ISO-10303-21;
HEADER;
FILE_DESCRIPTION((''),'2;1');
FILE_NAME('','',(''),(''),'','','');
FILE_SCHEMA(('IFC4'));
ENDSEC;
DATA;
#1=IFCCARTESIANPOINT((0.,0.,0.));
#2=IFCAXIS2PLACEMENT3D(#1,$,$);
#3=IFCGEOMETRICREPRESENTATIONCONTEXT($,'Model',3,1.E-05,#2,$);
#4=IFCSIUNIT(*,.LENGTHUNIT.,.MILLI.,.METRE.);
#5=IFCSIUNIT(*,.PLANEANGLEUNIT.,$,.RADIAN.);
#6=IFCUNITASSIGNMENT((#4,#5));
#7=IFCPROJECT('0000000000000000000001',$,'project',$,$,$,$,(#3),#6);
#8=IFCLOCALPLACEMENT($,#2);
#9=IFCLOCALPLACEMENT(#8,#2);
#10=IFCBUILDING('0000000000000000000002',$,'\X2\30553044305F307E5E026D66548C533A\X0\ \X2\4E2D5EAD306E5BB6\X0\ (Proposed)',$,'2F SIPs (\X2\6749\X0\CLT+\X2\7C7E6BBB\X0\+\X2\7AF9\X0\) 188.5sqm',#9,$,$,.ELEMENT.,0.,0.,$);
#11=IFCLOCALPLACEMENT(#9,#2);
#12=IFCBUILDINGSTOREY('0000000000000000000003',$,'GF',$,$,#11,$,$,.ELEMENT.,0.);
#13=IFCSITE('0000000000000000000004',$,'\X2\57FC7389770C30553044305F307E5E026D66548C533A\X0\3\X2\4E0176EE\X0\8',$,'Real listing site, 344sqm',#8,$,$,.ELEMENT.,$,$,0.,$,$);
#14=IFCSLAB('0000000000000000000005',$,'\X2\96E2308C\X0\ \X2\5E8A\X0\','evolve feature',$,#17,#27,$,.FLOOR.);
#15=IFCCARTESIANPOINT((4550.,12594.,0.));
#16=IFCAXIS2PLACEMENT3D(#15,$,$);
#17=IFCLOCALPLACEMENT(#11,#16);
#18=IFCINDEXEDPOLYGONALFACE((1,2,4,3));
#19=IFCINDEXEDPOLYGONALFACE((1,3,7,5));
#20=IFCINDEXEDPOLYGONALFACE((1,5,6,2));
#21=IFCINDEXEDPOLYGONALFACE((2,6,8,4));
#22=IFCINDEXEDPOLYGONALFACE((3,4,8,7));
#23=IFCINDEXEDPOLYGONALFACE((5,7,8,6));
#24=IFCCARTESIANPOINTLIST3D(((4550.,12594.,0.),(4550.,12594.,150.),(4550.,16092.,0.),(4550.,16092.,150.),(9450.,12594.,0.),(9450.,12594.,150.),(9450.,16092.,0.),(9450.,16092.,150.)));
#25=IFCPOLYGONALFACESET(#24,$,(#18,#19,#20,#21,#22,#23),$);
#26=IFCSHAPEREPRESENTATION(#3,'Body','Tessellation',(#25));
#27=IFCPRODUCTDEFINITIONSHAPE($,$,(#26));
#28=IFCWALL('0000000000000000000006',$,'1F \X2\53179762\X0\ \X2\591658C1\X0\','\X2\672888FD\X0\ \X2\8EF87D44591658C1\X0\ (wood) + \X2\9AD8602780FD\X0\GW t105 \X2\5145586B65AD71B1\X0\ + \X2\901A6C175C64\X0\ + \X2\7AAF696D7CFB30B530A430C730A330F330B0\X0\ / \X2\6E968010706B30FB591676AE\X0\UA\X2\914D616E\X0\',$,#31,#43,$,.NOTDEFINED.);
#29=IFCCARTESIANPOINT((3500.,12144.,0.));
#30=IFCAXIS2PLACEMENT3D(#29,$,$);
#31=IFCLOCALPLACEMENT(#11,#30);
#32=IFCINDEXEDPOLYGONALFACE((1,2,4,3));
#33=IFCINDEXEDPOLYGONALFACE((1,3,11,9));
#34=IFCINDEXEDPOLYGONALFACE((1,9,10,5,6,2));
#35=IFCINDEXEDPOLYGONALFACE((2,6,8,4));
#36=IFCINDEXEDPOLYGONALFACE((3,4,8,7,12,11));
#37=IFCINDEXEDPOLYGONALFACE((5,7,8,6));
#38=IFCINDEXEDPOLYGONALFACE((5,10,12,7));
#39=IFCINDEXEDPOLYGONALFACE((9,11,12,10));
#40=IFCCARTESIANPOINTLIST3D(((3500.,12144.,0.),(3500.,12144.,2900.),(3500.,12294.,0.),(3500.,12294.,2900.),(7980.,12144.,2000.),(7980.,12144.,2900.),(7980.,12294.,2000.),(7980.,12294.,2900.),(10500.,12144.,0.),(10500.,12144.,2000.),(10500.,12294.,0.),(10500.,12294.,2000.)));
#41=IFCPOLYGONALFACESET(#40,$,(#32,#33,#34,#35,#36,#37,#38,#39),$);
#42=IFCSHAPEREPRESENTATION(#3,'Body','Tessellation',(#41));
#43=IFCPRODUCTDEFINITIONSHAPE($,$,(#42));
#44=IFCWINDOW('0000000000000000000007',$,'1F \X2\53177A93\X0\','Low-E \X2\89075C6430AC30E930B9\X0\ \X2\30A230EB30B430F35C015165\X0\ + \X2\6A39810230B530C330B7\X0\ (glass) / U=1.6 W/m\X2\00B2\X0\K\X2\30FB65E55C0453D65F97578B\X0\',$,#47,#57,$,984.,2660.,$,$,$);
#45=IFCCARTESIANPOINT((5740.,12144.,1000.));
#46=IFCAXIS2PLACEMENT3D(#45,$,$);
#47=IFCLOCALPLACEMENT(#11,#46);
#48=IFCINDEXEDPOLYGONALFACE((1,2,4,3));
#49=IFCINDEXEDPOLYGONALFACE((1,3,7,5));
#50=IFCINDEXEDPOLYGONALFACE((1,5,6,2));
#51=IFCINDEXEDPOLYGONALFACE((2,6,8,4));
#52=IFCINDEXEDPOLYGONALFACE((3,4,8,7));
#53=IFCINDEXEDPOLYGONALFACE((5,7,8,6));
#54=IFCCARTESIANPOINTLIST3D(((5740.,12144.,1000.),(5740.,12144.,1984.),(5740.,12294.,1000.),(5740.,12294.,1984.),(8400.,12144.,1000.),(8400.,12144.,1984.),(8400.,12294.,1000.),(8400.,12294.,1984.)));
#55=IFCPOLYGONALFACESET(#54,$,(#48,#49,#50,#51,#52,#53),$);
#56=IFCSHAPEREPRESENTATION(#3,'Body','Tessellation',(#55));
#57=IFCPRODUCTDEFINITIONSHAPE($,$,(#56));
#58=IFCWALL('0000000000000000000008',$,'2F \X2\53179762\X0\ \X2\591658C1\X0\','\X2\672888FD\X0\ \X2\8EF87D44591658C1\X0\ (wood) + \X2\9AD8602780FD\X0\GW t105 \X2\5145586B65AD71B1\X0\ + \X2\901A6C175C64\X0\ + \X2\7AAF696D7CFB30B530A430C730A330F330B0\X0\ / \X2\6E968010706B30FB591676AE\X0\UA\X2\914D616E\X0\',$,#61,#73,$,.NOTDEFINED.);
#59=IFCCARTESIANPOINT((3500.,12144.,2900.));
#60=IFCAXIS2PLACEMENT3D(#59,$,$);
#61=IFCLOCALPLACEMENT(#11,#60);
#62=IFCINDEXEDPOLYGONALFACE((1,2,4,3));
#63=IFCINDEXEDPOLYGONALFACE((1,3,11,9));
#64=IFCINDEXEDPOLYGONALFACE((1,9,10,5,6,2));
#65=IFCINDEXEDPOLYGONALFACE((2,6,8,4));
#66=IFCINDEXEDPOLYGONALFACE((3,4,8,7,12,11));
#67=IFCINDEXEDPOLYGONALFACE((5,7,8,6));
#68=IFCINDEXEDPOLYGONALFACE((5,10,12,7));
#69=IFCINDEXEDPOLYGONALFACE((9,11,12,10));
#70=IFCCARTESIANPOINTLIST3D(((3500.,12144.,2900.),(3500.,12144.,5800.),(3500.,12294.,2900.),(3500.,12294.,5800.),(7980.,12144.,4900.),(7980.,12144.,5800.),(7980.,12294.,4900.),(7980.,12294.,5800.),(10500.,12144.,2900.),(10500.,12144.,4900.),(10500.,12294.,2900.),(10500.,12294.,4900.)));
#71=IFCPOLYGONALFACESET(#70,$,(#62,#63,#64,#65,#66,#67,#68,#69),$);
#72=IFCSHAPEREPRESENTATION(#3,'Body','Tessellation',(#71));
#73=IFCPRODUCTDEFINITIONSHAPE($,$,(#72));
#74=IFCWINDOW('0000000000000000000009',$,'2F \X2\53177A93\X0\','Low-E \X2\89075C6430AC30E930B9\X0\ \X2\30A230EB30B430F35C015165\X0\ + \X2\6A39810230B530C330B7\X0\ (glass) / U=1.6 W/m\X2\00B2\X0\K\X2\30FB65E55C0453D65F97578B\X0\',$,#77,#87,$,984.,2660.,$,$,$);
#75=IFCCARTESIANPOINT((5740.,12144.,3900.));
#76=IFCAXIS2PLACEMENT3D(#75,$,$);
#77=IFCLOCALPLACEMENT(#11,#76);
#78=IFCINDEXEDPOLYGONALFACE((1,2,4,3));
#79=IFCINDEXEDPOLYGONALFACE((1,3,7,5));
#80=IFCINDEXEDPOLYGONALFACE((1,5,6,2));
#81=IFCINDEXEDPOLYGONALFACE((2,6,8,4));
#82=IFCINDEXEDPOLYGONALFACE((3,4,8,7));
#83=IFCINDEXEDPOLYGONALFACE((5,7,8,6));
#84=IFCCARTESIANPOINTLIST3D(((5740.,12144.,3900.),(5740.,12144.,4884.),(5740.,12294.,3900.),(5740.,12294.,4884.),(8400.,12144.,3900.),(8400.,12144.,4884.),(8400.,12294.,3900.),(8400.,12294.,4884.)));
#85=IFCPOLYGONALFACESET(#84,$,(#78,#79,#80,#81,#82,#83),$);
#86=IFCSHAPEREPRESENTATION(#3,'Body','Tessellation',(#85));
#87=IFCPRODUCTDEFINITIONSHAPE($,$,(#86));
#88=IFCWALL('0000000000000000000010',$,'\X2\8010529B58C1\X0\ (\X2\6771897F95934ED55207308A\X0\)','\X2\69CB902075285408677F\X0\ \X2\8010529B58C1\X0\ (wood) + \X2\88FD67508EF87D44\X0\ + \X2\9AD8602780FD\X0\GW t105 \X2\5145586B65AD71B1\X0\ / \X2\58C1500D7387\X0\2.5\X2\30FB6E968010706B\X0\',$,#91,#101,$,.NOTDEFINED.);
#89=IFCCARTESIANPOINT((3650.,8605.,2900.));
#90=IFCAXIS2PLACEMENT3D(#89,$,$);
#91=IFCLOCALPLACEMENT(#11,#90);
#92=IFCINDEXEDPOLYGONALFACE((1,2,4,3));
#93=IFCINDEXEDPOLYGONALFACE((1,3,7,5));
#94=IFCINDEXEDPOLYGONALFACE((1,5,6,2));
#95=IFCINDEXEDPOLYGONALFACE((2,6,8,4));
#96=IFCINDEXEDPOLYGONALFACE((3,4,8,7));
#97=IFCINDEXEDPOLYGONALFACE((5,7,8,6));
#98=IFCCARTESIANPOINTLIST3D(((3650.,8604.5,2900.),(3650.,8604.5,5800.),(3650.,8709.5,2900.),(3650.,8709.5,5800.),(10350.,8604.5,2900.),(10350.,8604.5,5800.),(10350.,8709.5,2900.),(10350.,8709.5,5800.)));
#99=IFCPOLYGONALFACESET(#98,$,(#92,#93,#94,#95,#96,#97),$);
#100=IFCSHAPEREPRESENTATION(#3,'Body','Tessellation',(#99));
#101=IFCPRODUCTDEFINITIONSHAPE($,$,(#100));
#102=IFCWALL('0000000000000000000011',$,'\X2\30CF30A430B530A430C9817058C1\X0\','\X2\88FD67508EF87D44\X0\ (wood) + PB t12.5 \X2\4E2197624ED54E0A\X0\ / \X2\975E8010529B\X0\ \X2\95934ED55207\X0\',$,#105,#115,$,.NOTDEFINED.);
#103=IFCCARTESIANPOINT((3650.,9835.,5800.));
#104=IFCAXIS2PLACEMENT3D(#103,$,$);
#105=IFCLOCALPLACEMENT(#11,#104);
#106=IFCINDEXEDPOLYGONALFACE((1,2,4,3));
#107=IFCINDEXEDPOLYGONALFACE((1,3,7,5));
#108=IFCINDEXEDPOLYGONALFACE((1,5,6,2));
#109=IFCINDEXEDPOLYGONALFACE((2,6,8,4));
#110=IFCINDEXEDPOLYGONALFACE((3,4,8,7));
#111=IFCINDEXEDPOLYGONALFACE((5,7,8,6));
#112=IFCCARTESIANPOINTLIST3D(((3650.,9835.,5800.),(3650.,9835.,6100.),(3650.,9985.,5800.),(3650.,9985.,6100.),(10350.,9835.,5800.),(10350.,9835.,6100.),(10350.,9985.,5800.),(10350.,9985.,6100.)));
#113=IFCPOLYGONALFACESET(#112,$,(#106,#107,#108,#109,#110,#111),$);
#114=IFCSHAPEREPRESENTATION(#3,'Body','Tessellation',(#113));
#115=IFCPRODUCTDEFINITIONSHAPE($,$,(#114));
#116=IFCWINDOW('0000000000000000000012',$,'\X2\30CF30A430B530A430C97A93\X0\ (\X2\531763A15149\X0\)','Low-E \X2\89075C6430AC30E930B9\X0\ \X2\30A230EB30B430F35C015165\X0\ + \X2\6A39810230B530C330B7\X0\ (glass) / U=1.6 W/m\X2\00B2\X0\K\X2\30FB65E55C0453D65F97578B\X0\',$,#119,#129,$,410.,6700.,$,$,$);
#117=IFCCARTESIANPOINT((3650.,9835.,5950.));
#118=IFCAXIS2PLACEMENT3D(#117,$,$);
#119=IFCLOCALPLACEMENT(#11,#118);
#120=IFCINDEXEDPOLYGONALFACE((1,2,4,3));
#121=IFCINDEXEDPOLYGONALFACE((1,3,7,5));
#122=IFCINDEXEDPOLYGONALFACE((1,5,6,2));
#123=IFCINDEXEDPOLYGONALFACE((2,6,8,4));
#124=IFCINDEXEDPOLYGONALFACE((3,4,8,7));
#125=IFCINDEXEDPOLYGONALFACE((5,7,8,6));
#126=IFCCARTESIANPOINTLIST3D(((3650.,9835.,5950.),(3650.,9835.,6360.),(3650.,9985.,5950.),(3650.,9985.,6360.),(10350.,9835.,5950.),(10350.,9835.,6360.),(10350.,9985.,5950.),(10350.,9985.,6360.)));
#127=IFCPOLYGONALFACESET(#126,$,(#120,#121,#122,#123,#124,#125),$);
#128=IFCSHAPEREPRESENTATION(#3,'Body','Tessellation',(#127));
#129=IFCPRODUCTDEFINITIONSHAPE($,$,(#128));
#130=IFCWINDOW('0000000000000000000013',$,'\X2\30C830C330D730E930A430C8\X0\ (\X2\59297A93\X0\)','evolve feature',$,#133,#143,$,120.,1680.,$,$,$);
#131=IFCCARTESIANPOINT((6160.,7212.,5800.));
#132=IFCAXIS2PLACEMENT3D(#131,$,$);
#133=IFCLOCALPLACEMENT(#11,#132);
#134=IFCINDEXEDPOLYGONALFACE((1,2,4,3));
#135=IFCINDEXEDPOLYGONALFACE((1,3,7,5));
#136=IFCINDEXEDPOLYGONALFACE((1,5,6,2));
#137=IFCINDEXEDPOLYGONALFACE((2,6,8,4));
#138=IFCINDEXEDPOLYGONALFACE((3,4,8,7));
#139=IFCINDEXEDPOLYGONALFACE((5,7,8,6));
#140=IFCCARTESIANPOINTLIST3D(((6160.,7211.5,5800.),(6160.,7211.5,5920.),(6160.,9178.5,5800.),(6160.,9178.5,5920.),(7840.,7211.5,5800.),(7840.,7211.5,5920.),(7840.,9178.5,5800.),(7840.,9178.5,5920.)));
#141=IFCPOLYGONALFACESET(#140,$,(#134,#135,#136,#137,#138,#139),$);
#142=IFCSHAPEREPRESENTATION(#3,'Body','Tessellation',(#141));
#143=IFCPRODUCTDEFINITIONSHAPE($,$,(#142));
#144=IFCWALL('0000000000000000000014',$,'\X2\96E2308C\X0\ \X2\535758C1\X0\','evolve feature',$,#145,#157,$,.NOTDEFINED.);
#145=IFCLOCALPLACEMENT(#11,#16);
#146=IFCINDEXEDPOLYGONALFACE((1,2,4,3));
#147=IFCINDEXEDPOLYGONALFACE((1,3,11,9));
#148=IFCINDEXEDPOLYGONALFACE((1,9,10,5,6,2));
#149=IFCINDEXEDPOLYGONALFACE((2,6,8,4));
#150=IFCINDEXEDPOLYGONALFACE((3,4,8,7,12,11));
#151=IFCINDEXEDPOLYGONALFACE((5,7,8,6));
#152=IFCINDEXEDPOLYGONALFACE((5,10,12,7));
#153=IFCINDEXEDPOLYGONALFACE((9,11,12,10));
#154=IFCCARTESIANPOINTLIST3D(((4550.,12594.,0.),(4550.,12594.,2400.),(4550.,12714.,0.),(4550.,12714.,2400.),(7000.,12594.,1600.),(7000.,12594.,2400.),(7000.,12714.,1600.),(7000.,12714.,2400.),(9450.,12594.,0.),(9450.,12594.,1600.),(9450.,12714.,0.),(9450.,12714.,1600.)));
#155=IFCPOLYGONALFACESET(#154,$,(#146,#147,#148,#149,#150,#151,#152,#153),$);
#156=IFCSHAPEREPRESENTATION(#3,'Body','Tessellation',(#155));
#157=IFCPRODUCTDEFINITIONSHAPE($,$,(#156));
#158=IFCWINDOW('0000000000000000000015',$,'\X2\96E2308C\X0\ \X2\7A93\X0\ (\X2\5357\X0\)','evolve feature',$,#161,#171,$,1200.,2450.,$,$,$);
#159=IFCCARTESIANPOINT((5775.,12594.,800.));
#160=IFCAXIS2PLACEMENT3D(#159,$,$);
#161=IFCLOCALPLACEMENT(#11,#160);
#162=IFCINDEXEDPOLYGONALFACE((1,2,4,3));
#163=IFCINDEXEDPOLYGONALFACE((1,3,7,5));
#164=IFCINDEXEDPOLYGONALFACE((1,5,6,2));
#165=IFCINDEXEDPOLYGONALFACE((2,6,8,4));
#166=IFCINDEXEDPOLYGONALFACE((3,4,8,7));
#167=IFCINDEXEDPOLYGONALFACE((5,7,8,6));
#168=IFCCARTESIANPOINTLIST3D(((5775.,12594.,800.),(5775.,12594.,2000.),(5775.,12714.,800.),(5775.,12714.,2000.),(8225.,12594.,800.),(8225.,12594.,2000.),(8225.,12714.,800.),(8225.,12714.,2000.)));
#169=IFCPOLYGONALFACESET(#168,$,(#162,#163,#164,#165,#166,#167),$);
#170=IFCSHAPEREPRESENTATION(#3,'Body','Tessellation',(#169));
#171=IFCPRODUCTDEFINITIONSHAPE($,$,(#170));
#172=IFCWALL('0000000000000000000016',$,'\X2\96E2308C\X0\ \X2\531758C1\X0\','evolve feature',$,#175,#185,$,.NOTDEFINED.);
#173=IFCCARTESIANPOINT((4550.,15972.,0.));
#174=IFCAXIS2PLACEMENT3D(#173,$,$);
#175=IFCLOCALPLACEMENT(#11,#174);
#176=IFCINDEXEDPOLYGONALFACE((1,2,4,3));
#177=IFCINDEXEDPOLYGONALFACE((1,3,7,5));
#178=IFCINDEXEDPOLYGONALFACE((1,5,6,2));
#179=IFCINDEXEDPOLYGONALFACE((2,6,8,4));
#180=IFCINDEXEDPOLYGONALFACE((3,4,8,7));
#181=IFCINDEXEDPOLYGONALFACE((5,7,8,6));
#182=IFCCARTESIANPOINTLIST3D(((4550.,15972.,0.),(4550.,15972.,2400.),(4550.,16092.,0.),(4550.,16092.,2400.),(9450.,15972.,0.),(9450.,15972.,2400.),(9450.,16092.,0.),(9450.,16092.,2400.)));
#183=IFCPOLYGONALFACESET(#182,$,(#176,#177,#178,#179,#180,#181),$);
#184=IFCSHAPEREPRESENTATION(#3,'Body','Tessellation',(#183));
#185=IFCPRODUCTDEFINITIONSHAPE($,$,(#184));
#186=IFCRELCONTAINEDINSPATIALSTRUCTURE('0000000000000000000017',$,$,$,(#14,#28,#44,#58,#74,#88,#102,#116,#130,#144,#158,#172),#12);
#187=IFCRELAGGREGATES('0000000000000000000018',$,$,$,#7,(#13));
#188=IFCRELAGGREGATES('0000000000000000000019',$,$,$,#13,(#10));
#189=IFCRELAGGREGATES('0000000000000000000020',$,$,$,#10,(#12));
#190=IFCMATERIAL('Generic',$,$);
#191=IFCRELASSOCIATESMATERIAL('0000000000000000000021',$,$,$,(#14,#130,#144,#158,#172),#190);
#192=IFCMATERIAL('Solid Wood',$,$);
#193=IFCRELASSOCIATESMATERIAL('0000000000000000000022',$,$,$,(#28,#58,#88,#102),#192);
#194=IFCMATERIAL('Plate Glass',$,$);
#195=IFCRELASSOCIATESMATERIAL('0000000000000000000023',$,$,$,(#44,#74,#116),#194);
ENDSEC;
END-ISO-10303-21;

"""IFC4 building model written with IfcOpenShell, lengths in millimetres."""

from ifc_helpers import new_model, si_unit, frame, frame_2d, origin, place, context, project, spatial, rectangle, extrude, material, element, fill, save


model = new_model("IFC4")

# Units and contexts
model_context = context("Model", 3, precision=1e-05, world=origin())
ifc_project = project(units=[si_unit("LENGTHUNIT", "METRE", prefix="MILLI"), si_unit("PLANEANGLEUNIT", "RADIAN")], contexts=[model_context])

# Site, building, storey
site_placement = place(None, origin())
site = spatial("IfcSite", under=ifc_project, at=site_placement, Name="埼玉県さいたま市浦和区3丁目8", ObjectType="Real listing site, 344sqm", CompositionType="ELEMENT", RefElevation=0.0)
building_placement = place(site_placement, origin())
building = spatial("IfcBuilding", under=site, at=building_placement, Name="さいたま市浦和区 中庭の家 (Proposed)", ObjectType="2F SIPs (杉CLT+籾殻+竹) 188.5sqm", CompositionType="ELEMENT", ElevationOfRefHeight=0.0, ElevationOfTerrain=0.0)
storey_placement = place(building_placement, origin())
storey = spatial("IfcBuildingStorey", under=building, at=storey_placement, Name="GF", CompositionType="ELEMENT", Elevation=0.0)

# Slab
ifc_material_1 = material(Name="Generic")
slab_placement = place(storey_placement, frame((4550.0, 12594.0, 0.0)))
element("IfcSlab", 1, at=slab_placement, inside=storey, material=ifc_material_1, Name="離れ 床", Description="evolve feature", PredefinedType="FLOOR", context=model_context, shape_type="SweptSolid", body=[
    extrude(rectangle(XDim=4900.0, YDim=3498.0, at=frame_2d((2450.0, 1749.0))), frame((4550.0, 12594.0, 0.0)), (0.0, 0.0, 1.0), 150.0),
])

# Wall, opening, window
ifc_material_2 = material(Name="Solid Wood")
wall_1_placement = place(storey_placement, frame((3500.0, 12144.0, 0.0)))
wall_1 = element("IfcWall", 2, at=wall_1_placement, inside=storey, material=ifc_material_2, Name="1F 北面 外壁", Description="木製 軸組外壁 (wood) + 高性能GW t105 充填断熱 + 通気層 + 窯業系サイディング / 準耐火・外皮UA配慮", PredefinedType="NOTDEFINED", context=model_context, shape_type="SweptSolid", body=[
    extrude(rectangle(XDim=7000.0, YDim=150.0, at=frame_2d((3500.0, 75.0))), frame((3500.0, 12144.0, 0.0)), (0.0, 0.0, 1.0), 2900.0),
])
opening_1_placement = place(storey_placement, frame((5740.0, 12144.0, 1000.0)))
opening_1 = element("IfcOpeningElement", 3, at=opening_1_placement, cuts=wall_1, PredefinedType="NOTDEFINED", context=model_context, shape_type="SweptSolid", body=[
    extrude(rectangle(XDim=2660.0, YDim=150.0, at=frame_2d((1330.0, 75.0))), frame((5740.0, 12144.0, 1000.0)), (0.0, 0.0, 1.0), 984.0),
])
ifc_material_3 = material(Name="Plate Glass")
window_1_placement = place(storey_placement, frame((5740.0, 12144.0, 1000.0)))
window_1 = element("IfcWindow", 4, at=window_1_placement, inside=storey, material=ifc_material_3, Name="1F 北窓", Description="Low-E 複層ガラス アルゴン封入 + 樹脂サッシ (glass) / U=1.6 W/m²K・日射取得型", OverallHeight=984.0, OverallWidth=2660.0, context=model_context, shape_type="SweptSolid", body=[
    extrude(rectangle(XDim=2660.0, YDim=150.0, at=frame_2d((1330.0, 75.0))), frame((5740.0, 12144.0, 1000.0)), (0.0, 0.0, 1.0), 984.0),
])
fill(opening_1, window_1)

# Wall, opening, window
wall_2_placement = place(storey_placement, frame((3500.0, 12144.0, 2900.0)))
wall_2 = element("IfcWall", 5, at=wall_2_placement, inside=storey, material=ifc_material_2, Name="2F 北面 外壁", Description="木製 軸組外壁 (wood) + 高性能GW t105 充填断熱 + 通気層 + 窯業系サイディング / 準耐火・外皮UA配慮", PredefinedType="NOTDEFINED", context=model_context, shape_type="SweptSolid", body=[
    extrude(rectangle(XDim=7000.0, YDim=150.0, at=frame_2d((3500.0, 75.0))), frame((3500.0, 12144.0, 2900.0)), (0.0, 0.0, 1.0), 2900.0),
])
opening_2_placement = place(storey_placement, frame((5740.0, 12144.0, 3900.0)))
opening_2 = element("IfcOpeningElement", 6, at=opening_2_placement, cuts=wall_2, PredefinedType="NOTDEFINED", context=model_context, shape_type="SweptSolid", body=[
    extrude(rectangle(XDim=2660.0, YDim=150.0, at=frame_2d((1330.0, 75.0))), frame((5740.0, 12144.0, 3900.0)), (0.0, 0.0, 1.0), 984.0),
])
window_2_placement = place(storey_placement, frame((5740.0, 12144.0, 3900.0)))
window_2 = element("IfcWindow", 7, at=window_2_placement, inside=storey, material=ifc_material_3, Name="2F 北窓", Description="Low-E 複層ガラス アルゴン封入 + 樹脂サッシ (glass) / U=1.6 W/m²K・日射取得型", OverallHeight=984.0, OverallWidth=2660.0, context=model_context, shape_type="SweptSolid", body=[
    extrude(rectangle(XDim=2660.0, YDim=150.0, at=frame_2d((1330.0, 75.0))), frame((5740.0, 12144.0, 3900.0)), (0.0, 0.0, 1.0), 984.0),
])
fill(opening_2, window_2)

# Wall
wall_3_placement = place(storey_placement, frame((3650.0, 8605.0, 2900.0)))
element("IfcWall", 8, at=wall_3_placement, inside=storey, material=ifc_material_2, Name="耐力壁 (東西間仕切り)", Description="構造用合板 耐力壁 (wood) + 製材軸組 + 高性能GW t105 充填断熱 / 壁倍率2.5・準耐火", PredefinedType="NOTDEFINED", context=model_context, shape_type="SweptSolid", body=[
    extrude(rectangle(XDim=6700.0, YDim=105.0, at=frame_2d((3350.0, 52.0))), frame((3650.0, 8605.0, 2900.0)), (0.0, 0.0, 1.0), 2900.0),
])

# Wall, opening, window
wall_4_placement = place(storey_placement, frame((3650.0, 9835.0, 5800.0)))
wall_4 = element("IfcWall", 9, at=wall_4_placement, inside=storey, material=ifc_material_2, Name="ハイサイド腰壁", Description="製材軸組 (wood) + PB t12.5 両面仕上 / 非耐力 間仕切", PredefinedType="NOTDEFINED", context=model_context, shape_type="SweptSolid", body=[
    extrude(rectangle(XDim=6700.0, YDim=150.0, at=frame_2d((3350.0, 75.0))), frame((3650.0, 9835.0, 5800.0)), (0.0, 0.0, 1.0), 700.0),
])
opening_3_placement = place(storey_placement, frame((3650.0, 9835.0, 5950.0)))
opening_3 = element("IfcOpeningElement", 10, at=opening_3_placement, cuts=wall_4, PredefinedType="NOTDEFINED", context=model_context, shape_type="SweptSolid", body=[
    extrude(rectangle(XDim=6700.0, YDim=150.0, at=frame_2d((3350.0, 75.0))), frame((3650.0, 9835.0, 5950.0)), (0.0, 0.0, 1.0), 410.0),
])
window_3_placement = place(storey_placement, frame((3650.0, 9835.0, 5950.0)))
window_3 = element("IfcWindow", 11, at=window_3_placement, inside=storey, material=ifc_material_3, Name="ハイサイド窓 (北採光)", Description="Low-E 複層ガラス アルゴン封入 + 樹脂サッシ (glass) / U=1.6 W/m²K・日射取得型", OverallHeight=410.0, OverallWidth=6700.0, context=model_context, shape_type="SweptSolid", body=[
    extrude(rectangle(XDim=6700.0, YDim=150.0, at=frame_2d((3350.0, 75.0))), frame((3650.0, 9835.0, 5950.0)), (0.0, 0.0, 1.0), 410.0),
])
fill(opening_3, window_3)

# Window
window_4_placement = place(storey_placement, frame((6160.0, 7212.0, 5800.0)))
element("IfcWindow", 12, at=window_4_placement, inside=storey, material=ifc_material_1, Name="トップライト (天窓)", Description="evolve feature", OverallHeight=120.0, OverallWidth=1680.0, context=model_context, shape_type="SweptSolid", body=[
    extrude(rectangle(XDim=1680.0, YDim=1967.0, at=frame_2d((840.0, 983.0))), frame((6160.0, 7212.0, 5800.0)), (0.0, 0.0, 1.0), 120.0),
])

# Wall, opening, window
wall_5_placement = place(storey_placement, frame((4550.0, 12594.0, 0.0)))
wall_5 = element("IfcWall", 13, at=wall_5_placement, inside=storey, material=ifc_material_1, Name="離れ 南壁", Description="evolve feature", PredefinedType="NOTDEFINED", context=model_context, shape_type="SweptSolid", body=[
    extrude(rectangle(XDim=4900.0, YDim=120.0, at=frame_2d((2450.0, 60.0))), frame((4550.0, 12594.0, 0.0)), (0.0, 0.0, 1.0), 2400.0),
])
opening_4_placement = place(storey_placement, frame((5775.0, 12594.0, 800.0)))
opening_4 = element("IfcOpeningElement", 14, at=opening_4_placement, cuts=wall_5, PredefinedType="NOTDEFINED", context=model_context, shape_type="SweptSolid", body=[
    extrude(rectangle(XDim=2450.0, YDim=120.0, at=frame_2d((1225.0, 60.0))), frame((5775.0, 12594.0, 800.0)), (0.0, 0.0, 1.0), 1200.0),
])
window_5_placement = place(storey_placement, frame((5775.0, 12594.0, 800.0)))
window_5 = element("IfcWindow", 15, at=window_5_placement, inside=storey, material=ifc_material_1, Name="離れ 窓 (南)", Description="evolve feature", OverallHeight=1200.0, OverallWidth=2450.0, context=model_context, shape_type="SweptSolid", body=[
    extrude(rectangle(XDim=2450.0, YDim=120.0, at=frame_2d((1225.0, 60.0))), frame((5775.0, 12594.0, 800.0)), (0.0, 0.0, 1.0), 1200.0),
])
fill(opening_4, window_5)

# Wall
wall_6_placement = place(storey_placement, frame((4550.0, 15972.0, 0.0)))
element("IfcWall", 16, at=wall_6_placement, inside=storey, material=ifc_material_1, Name="離れ 北壁", Description="evolve feature", PredefinedType="NOTDEFINED", context=model_context, shape_type="SweptSolid", body=[
    extrude(rectangle(XDim=4900.0, YDim=120.0, at=frame_2d((2450.0, 60.0))), frame((4550.0, 15972.0, 0.0)), (0.0, 0.0, 1.0), 2400.0),
])

save(model, "model.ifc")
